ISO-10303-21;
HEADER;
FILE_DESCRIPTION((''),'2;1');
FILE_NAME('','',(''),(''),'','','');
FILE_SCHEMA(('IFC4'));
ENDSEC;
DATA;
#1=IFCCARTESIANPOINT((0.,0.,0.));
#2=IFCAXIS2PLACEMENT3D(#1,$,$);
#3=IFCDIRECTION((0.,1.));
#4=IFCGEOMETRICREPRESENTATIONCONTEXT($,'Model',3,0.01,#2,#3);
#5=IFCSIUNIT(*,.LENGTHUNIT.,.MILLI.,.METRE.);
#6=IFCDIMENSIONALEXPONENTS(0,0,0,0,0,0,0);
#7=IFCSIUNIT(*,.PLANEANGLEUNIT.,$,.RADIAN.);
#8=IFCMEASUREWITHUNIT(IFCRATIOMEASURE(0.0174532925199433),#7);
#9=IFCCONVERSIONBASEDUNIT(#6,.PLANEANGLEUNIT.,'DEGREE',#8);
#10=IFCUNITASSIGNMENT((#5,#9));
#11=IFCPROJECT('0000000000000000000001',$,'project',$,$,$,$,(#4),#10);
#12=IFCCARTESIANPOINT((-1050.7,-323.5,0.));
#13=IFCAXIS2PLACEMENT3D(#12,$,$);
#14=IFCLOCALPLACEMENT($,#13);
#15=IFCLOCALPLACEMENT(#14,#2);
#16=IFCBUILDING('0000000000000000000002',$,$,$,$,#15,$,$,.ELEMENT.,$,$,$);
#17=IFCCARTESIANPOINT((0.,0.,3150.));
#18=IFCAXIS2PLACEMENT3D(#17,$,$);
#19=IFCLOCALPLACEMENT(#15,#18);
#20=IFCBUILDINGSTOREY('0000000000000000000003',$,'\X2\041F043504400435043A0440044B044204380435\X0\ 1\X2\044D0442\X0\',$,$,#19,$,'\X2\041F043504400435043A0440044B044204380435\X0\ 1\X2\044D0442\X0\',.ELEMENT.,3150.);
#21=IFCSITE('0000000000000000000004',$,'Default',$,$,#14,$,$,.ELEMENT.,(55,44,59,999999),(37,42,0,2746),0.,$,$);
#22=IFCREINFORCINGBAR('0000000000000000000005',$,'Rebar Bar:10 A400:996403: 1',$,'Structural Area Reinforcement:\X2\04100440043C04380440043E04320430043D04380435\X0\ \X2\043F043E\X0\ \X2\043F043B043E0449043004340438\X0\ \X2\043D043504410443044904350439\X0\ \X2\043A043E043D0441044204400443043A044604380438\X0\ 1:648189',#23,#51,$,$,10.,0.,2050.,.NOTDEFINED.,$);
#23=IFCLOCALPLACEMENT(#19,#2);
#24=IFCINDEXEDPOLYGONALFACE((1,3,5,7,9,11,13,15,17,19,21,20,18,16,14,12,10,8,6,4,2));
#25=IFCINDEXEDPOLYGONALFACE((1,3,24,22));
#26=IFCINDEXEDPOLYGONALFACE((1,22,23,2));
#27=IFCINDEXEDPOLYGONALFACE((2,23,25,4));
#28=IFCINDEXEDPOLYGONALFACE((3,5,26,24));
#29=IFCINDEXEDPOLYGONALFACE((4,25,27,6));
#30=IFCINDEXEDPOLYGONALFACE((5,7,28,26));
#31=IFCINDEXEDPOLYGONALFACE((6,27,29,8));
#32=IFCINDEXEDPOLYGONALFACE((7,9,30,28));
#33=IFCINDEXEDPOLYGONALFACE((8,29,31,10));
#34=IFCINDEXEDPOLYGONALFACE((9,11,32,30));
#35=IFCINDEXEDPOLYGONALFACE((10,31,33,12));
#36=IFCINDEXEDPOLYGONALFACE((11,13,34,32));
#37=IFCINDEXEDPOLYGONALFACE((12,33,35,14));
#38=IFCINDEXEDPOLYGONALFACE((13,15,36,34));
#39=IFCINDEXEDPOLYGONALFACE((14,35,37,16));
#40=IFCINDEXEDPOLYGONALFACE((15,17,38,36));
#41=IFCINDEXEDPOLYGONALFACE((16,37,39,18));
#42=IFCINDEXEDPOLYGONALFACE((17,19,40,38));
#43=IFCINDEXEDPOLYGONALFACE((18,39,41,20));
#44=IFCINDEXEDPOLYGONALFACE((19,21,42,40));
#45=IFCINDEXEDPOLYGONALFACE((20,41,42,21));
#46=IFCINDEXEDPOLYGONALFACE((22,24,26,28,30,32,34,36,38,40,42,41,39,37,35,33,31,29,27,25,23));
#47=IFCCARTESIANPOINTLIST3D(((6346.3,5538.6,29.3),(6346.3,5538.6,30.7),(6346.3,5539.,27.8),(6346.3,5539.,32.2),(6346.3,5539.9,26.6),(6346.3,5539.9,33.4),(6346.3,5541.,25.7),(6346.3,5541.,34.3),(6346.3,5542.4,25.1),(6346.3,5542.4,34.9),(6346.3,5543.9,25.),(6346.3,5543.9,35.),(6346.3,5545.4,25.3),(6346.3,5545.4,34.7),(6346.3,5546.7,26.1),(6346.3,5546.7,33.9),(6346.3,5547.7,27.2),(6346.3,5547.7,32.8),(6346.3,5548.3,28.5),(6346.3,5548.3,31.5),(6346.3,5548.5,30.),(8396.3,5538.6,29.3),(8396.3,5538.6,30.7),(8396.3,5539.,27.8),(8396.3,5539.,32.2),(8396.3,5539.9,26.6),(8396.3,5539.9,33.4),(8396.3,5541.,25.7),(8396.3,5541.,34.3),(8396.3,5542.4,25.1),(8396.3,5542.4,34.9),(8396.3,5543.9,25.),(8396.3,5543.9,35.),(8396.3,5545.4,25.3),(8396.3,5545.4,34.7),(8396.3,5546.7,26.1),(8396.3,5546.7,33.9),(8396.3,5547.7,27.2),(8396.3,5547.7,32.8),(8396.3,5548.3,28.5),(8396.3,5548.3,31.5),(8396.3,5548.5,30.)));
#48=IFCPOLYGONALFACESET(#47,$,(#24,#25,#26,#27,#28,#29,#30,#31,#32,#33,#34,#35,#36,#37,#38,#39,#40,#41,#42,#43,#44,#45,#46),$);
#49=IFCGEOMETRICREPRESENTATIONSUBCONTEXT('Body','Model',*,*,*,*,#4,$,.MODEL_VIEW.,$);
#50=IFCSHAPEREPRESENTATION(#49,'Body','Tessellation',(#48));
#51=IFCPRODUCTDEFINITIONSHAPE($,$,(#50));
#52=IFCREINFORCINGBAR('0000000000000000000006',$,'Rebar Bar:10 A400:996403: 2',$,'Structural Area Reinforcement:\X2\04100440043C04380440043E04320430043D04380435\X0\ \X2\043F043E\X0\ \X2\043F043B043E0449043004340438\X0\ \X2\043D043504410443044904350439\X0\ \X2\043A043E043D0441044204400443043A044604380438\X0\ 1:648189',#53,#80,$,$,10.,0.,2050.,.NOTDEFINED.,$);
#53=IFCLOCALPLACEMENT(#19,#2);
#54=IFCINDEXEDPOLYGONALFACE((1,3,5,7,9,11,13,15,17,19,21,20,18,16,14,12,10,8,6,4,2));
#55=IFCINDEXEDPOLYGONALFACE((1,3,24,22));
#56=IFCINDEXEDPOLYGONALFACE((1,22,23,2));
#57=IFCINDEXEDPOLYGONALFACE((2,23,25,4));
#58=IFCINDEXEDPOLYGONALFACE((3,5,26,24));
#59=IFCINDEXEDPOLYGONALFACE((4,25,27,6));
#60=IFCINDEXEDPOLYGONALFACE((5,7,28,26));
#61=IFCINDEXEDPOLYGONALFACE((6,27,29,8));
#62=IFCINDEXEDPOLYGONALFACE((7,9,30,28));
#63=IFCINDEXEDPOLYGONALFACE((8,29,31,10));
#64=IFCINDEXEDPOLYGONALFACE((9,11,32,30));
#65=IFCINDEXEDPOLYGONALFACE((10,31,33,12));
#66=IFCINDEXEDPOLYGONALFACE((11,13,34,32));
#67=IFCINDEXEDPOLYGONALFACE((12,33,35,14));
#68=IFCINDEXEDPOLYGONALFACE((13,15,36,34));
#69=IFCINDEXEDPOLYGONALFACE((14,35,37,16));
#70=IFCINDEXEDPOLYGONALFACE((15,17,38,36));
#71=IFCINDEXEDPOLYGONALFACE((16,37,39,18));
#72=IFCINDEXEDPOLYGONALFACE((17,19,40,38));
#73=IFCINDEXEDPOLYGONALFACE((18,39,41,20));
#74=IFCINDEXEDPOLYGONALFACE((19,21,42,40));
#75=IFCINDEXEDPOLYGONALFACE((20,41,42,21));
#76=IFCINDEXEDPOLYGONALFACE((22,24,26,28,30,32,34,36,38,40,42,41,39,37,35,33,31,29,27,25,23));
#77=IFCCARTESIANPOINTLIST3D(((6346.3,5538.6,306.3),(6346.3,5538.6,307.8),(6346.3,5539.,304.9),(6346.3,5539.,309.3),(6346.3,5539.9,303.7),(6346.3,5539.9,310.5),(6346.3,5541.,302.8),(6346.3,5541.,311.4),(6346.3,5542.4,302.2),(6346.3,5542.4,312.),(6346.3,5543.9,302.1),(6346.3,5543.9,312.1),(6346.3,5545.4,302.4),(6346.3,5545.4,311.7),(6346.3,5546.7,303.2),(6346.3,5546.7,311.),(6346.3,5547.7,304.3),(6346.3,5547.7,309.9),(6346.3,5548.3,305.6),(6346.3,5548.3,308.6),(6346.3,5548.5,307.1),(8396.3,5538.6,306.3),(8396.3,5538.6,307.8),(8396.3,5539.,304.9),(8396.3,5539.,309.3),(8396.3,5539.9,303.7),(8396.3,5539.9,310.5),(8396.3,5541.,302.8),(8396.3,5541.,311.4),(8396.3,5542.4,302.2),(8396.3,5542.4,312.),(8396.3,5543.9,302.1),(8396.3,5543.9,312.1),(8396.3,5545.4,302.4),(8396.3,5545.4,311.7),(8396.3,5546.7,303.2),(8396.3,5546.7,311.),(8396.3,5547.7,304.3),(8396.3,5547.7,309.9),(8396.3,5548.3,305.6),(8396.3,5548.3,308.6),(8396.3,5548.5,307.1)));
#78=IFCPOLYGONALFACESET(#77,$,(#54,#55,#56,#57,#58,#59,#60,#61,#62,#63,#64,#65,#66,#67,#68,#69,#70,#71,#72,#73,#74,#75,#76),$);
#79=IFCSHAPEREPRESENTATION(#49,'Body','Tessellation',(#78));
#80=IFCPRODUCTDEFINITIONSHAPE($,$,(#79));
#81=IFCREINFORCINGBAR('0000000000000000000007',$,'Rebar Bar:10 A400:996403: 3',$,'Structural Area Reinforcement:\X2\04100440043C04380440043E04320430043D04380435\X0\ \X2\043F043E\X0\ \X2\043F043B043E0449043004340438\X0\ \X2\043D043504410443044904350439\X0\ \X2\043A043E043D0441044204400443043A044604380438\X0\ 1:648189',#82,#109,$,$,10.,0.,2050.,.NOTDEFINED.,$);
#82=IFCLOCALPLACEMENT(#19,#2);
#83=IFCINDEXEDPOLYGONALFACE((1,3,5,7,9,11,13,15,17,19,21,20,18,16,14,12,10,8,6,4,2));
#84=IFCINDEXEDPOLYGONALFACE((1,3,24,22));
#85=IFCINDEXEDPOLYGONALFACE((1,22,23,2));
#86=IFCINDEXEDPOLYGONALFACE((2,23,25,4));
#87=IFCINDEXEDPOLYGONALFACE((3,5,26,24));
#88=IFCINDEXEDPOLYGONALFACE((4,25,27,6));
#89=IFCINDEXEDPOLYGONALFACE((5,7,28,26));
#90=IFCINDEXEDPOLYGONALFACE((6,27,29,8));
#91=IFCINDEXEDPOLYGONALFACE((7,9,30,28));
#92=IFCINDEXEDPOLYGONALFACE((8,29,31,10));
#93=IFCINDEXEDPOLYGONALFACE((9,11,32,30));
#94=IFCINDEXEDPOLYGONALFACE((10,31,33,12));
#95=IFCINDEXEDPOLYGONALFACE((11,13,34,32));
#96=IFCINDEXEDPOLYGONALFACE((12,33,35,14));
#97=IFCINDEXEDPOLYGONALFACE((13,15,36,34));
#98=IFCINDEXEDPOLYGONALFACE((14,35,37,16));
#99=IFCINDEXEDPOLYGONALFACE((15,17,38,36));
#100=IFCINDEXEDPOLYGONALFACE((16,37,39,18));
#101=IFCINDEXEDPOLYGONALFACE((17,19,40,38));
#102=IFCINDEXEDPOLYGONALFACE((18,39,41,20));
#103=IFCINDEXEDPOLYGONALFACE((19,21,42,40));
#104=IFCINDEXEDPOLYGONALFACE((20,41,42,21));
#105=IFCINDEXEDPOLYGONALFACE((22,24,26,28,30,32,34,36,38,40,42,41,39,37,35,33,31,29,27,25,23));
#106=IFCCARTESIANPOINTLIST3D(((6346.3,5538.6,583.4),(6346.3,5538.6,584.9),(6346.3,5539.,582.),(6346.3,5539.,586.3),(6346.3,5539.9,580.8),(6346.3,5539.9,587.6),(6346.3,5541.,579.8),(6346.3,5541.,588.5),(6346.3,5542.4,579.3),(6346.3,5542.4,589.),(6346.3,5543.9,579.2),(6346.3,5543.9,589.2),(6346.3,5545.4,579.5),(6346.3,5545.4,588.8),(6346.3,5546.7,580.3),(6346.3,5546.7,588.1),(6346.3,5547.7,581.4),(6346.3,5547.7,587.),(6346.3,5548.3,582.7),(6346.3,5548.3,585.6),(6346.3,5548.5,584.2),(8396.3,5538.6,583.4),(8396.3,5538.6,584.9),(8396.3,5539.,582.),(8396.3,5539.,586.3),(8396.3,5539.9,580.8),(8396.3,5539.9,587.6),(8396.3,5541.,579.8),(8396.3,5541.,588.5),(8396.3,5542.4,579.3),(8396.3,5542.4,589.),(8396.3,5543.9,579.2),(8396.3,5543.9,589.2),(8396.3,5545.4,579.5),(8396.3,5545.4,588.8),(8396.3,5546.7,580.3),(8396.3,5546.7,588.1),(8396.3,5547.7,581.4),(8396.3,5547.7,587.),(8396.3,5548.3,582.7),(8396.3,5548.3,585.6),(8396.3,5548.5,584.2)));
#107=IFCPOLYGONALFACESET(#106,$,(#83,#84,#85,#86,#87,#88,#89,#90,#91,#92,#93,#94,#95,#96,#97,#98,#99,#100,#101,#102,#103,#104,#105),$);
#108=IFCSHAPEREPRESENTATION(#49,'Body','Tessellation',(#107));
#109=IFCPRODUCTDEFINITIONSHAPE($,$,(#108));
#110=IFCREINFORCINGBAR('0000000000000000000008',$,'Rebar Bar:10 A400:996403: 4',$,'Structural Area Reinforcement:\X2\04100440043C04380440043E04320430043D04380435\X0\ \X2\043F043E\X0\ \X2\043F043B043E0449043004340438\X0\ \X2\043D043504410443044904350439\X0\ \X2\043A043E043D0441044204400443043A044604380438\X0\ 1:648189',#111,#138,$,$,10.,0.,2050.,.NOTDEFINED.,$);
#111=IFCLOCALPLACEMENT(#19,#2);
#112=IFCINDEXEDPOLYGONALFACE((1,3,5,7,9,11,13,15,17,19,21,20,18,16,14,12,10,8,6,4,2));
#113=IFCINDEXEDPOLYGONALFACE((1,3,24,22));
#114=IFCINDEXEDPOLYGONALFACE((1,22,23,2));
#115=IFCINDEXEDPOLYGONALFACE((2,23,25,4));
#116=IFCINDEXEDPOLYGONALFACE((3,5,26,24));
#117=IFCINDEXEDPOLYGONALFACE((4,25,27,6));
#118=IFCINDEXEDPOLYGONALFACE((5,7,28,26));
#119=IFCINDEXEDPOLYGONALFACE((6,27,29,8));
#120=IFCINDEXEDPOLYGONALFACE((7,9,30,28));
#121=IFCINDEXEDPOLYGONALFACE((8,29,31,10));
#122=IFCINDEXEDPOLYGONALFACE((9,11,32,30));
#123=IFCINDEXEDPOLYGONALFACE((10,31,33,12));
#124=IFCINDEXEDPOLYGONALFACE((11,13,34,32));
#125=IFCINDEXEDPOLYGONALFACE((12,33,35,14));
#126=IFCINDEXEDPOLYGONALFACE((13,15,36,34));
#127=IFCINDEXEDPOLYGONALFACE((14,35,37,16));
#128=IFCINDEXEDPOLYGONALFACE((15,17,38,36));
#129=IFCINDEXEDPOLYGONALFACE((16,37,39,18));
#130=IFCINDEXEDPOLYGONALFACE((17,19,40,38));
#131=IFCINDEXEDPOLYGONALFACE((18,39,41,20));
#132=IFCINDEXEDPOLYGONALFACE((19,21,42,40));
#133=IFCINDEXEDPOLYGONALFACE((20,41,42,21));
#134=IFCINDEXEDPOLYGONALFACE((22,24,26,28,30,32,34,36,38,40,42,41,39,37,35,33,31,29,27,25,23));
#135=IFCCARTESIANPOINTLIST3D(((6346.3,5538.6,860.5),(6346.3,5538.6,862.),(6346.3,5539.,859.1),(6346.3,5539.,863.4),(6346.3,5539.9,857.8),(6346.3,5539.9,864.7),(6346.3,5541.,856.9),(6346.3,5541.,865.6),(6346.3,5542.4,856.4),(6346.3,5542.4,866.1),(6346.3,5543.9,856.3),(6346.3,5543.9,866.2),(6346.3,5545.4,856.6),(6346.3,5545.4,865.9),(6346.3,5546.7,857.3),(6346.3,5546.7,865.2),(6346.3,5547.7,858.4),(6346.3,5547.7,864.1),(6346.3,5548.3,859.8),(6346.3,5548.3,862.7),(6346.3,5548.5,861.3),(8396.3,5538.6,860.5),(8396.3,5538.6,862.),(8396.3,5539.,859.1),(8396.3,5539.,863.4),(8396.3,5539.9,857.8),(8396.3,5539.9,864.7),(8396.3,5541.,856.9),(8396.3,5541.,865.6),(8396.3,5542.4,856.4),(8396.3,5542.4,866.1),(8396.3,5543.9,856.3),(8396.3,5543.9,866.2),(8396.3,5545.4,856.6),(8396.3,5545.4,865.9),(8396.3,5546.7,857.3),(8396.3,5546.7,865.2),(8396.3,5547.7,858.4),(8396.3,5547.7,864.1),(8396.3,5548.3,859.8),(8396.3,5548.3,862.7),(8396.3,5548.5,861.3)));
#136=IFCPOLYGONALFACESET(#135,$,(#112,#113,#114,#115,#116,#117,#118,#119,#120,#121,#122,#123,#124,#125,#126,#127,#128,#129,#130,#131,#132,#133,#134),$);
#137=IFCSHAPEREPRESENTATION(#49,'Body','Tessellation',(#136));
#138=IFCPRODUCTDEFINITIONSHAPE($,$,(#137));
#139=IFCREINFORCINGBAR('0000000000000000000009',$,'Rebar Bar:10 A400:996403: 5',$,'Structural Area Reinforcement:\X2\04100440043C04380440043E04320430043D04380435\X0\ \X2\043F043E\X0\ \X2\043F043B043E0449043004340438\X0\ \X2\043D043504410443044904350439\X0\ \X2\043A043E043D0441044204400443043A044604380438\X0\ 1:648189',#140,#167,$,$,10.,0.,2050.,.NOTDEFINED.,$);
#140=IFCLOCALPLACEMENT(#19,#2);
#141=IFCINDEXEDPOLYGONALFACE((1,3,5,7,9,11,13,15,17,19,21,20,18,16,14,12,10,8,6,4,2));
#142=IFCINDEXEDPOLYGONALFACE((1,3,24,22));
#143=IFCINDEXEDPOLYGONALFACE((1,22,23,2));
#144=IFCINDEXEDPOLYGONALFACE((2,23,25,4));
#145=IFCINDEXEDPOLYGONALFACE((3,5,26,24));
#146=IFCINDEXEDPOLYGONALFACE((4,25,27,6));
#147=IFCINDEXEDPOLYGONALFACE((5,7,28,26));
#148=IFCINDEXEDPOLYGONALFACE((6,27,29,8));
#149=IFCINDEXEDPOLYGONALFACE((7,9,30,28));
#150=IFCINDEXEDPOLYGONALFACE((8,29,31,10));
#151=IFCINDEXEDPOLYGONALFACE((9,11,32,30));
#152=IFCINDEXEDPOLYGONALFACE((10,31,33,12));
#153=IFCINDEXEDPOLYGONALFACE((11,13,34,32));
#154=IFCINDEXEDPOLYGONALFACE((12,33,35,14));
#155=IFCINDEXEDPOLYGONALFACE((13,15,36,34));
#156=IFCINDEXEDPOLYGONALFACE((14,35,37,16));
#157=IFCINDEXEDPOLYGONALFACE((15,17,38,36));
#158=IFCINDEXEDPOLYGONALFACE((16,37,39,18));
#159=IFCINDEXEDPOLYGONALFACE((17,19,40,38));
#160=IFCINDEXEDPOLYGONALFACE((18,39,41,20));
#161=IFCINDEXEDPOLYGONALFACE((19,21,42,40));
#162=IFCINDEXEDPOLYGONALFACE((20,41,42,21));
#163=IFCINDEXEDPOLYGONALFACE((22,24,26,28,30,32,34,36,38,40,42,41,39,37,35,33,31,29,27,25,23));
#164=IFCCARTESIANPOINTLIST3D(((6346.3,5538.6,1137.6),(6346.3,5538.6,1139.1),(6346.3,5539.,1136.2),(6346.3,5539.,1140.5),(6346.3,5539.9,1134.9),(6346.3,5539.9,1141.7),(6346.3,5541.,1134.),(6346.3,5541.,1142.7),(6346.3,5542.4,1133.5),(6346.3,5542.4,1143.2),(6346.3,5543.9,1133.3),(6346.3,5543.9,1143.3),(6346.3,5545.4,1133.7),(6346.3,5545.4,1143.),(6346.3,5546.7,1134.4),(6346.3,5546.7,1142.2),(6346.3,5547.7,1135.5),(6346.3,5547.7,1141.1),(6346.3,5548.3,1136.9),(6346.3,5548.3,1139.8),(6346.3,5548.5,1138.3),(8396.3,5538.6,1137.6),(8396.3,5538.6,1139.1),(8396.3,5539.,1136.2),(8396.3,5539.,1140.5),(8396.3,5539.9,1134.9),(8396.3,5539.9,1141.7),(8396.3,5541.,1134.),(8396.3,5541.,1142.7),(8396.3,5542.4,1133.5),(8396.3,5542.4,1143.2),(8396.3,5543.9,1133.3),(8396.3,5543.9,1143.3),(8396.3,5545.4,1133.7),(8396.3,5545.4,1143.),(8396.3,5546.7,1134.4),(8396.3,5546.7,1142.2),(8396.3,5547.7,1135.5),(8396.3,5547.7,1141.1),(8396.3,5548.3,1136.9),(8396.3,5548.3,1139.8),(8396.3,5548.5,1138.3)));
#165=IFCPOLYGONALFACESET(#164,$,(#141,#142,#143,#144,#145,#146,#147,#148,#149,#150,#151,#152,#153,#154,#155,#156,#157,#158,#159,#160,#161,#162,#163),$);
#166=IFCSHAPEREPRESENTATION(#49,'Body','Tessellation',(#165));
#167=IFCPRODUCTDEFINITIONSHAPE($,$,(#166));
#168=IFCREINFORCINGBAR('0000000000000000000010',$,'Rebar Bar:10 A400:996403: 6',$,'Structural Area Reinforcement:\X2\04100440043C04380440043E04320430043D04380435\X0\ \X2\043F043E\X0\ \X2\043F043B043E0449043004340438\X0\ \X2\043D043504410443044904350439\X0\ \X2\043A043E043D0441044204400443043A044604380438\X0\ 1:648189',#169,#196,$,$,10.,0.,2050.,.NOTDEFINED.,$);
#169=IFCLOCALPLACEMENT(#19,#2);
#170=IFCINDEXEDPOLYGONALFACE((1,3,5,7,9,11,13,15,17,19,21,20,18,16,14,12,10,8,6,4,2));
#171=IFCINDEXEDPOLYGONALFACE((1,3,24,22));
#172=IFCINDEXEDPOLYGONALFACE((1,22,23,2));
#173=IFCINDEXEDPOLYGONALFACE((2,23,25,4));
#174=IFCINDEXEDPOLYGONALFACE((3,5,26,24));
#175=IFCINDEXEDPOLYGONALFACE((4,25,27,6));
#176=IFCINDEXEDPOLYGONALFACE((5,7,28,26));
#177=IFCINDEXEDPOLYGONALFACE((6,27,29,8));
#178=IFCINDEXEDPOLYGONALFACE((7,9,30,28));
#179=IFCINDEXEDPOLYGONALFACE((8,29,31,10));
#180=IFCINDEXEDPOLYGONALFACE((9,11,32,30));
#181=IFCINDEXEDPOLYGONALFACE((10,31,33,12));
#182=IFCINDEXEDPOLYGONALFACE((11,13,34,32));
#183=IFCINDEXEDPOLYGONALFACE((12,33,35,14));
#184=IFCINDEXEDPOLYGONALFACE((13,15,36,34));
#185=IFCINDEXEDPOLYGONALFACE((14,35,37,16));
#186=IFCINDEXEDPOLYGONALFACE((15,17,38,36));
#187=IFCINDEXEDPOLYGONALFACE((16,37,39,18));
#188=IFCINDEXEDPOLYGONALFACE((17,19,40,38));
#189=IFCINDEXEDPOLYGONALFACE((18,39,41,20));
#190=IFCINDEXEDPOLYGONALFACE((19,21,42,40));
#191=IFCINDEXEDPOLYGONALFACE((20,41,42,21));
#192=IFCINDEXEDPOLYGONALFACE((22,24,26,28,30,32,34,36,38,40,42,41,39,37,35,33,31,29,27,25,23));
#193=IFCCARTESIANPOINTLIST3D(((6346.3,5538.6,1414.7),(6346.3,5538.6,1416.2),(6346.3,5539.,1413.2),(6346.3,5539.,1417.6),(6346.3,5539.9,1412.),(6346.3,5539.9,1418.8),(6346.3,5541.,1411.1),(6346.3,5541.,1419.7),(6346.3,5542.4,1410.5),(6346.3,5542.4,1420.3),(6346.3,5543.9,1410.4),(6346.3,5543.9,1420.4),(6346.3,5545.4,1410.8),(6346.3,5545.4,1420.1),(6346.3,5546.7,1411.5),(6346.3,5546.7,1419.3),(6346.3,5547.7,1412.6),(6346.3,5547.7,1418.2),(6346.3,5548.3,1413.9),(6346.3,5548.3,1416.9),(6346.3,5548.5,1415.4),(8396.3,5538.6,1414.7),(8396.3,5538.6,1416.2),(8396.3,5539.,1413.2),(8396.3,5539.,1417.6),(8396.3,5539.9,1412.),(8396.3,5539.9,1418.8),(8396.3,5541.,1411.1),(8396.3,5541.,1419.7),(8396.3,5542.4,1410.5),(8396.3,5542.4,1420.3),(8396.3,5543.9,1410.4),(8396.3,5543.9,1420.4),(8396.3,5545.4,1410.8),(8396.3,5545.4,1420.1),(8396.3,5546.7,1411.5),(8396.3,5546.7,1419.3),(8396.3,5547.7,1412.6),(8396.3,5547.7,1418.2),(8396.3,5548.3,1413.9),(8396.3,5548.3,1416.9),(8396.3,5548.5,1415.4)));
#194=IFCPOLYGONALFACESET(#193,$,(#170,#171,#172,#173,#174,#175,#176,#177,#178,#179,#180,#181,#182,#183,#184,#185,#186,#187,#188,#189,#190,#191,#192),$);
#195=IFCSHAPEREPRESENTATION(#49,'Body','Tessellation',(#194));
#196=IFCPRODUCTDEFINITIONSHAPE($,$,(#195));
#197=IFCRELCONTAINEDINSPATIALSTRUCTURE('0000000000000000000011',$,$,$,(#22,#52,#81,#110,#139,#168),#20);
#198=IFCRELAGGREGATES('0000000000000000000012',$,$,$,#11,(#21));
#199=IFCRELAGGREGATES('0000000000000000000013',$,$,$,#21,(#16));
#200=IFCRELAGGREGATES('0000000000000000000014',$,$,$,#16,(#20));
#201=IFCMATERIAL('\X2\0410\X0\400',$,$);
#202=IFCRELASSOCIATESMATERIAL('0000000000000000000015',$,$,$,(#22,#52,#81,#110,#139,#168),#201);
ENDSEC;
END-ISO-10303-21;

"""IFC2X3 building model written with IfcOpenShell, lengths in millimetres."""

from ifc_helpers import new_model, entity, si_unit, converted_unit, direction, frame, origin, place, context, subcontext, project, spatial, material, element, save


model = new_model("IFC2X3")

# Units and contexts
model_context = context("Model", 3, precision=0.01, world=origin(), true_north=direction((0.0, 1.0)))
body_context = subcontext(model_context, "Body", "Model", "MODEL_VIEW")
ifc_project = project(units=[si_unit("LENGTHUNIT", "METRE", prefix="MILLI"), converted_unit("PLANEANGLEUNIT", "DEGREE", entity("IfcRatioMeasure", 0.0174532925199433), si_unit("PLANEANGLEUNIT", "RADIAN"), dimensions=[0, 0, 0, 0, 0, 0, 0])], contexts=[model_context])

# Site, building, storey
site_placement = place(None, frame((-1050.7, -323.5, 0.0)))
site = spatial("IfcSite", under=ifc_project, at=site_placement, Name="Default", CompositionType="ELEMENT", RefLatitude=(55, 44, 59, 999999), RefLongitude=(37, 42, 0, 2746), RefElevation=0.0)
building_placement = place(site_placement, origin())
building = spatial("IfcBuilding", under=site, at=building_placement, CompositionType="ELEMENT")
storey_placement = place(building_placement, frame((0.0, 0.0, 3150.0)))
storey = spatial("IfcBuildingStorey", under=building, at=storey_placement, Name="Перекрытие 1эт", LongName="Перекрытие 1эт", CompositionType="ELEMENT", Elevation=3150.0)

# Reinforcing bars
ifc_material = material(Name="А400")
reinforcing_bar_1_placement = place(storey_placement, origin())
element("IfcReinforcingBar", 1, at=reinforcing_bar_1_placement, inside=storey, material=ifc_material, Name="Rebar Bar:10 A400:996403: 1", ObjectType="Structural Area Reinforcement:Армирование по площади несущей конструкции 1:648189", BarLength=2050.0, BarRole="NOTDEFINED", CrossSectionArea=0.0, NominalDiameter=10.0, context=body_context, shape_type="AdvancedSweptSolid", body=[
    entity("IfcSweptDiskSolid", entity("IfcCompositeCurve", [entity("IfcCompositeCurveSegment", "CONTINUOUS", True, entity("IfcPolyline", [entity("IfcCartesianPoint", [6346.3, 5543.5, 30.0]), entity("IfcCartesianPoint", [8396.3, 5543.5, 30.0])]))], False), 5.0, None, 0.0, 1.0),
])
reinforcing_bar_2_placement = place(storey_placement, origin())
element("IfcReinforcingBar", 2, at=reinforcing_bar_2_placement, inside=storey, material=ifc_material, Name="Rebar Bar:10 A400:996403: 2", ObjectType="Structural Area Reinforcement:Армирование по площади несущей конструкции 1:648189", BarLength=2050.0, BarRole="NOTDEFINED", CrossSectionArea=0.0, NominalDiameter=10.0, context=body_context, shape_type="AdvancedSweptSolid", body=[
    entity("IfcSweptDiskSolid", entity("IfcCompositeCurve", [entity("IfcCompositeCurveSegment", "CONTINUOUS", True, entity("IfcPolyline", [entity("IfcCartesianPoint", [6346.3, 5543.5, 307.1]), entity("IfcCartesianPoint", [8396.3, 5543.5, 307.1])]))], False), 5.0, None, 0.0, 1.0),
])
reinforcing_bar_3_placement = place(storey_placement, origin())
element("IfcReinforcingBar", 3, at=reinforcing_bar_3_placement, inside=storey, material=ifc_material, Name="Rebar Bar:10 A400:996403: 3", ObjectType="Structural Area Reinforcement:Армирование по площади несущей конструкции 1:648189", BarLength=2050.0, BarRole="NOTDEFINED", CrossSectionArea=0.0, NominalDiameter=10.0, context=body_context, shape_type="AdvancedSweptSolid", body=[
    entity("IfcSweptDiskSolid", entity("IfcCompositeCurve", [entity("IfcCompositeCurveSegment", "CONTINUOUS", True, entity("IfcPolyline", [entity("IfcCartesianPoint", [6346.3, 5543.5, 584.2]), entity("IfcCartesianPoint", [8396.3, 5543.5, 584.2])]))], False), 5.0, None, 0.0, 1.0),
])
reinforcing_bar_4_placement = place(storey_placement, origin())
element("IfcReinforcingBar", 4, at=reinforcing_bar_4_placement, inside=storey, material=ifc_material, Name="Rebar Bar:10 A400:996403: 4", ObjectType="Structural Area Reinforcement:Армирование по площади несущей конструкции 1:648189", BarLength=2050.0, BarRole="NOTDEFINED", CrossSectionArea=0.0, NominalDiameter=10.0, context=body_context, shape_type="AdvancedSweptSolid", body=[
    entity("IfcSweptDiskSolid", entity("IfcCompositeCurve", [entity("IfcCompositeCurveSegment", "CONTINUOUS", True, entity("IfcPolyline", [entity("IfcCartesianPoint", [6346.3, 5543.5, 861.3]), entity("IfcCartesianPoint", [8396.3, 5543.5, 861.3])]))], False), 5.0, None, 0.0, 1.0),
])
reinforcing_bar_5_placement = place(storey_placement, origin())
element("IfcReinforcingBar", 5, at=reinforcing_bar_5_placement, inside=storey, material=ifc_material, Name="Rebar Bar:10 A400:996403: 5", ObjectType="Structural Area Reinforcement:Армирование по площади несущей конструкции 1:648189", BarLength=2050.0, BarRole="NOTDEFINED", CrossSectionArea=0.0, NominalDiameter=10.0, context=body_context, shape_type="AdvancedSweptSolid", body=[
    entity("IfcSweptDiskSolid", entity("IfcCompositeCurve", [entity("IfcCompositeCurveSegment", "CONTINUOUS", True, entity("IfcPolyline", [entity("IfcCartesianPoint", [6346.3, 5543.5, 1138.3]), entity("IfcCartesianPoint", [8396.3, 5543.5, 1138.3])]))], False), 5.0, None, 0.0, 1.0),
])
reinforcing_bar_6_placement = place(storey_placement, origin())
element("IfcReinforcingBar", 6, at=reinforcing_bar_6_placement, inside=storey, material=ifc_material, Name="Rebar Bar:10 A400:996403: 6", ObjectType="Structural Area Reinforcement:Армирование по площади несущей конструкции 1:648189", BarLength=2050.0, BarRole="NOTDEFINED", CrossSectionArea=0.0, NominalDiameter=10.0, context=body_context, shape_type="AdvancedSweptSolid", body=[
    entity("IfcSweptDiskSolid", entity("IfcCompositeCurve", [entity("IfcCompositeCurveSegment", "CONTINUOUS", True, entity("IfcPolyline", [entity("IfcCartesianPoint", [6346.3, 5543.5, 1415.4]), entity("IfcCartesianPoint", [8396.3, 5543.5, 1415.4])]))], False), 5.0, None, 0.0, 1.0),
])

save(model, "model.ifc")
